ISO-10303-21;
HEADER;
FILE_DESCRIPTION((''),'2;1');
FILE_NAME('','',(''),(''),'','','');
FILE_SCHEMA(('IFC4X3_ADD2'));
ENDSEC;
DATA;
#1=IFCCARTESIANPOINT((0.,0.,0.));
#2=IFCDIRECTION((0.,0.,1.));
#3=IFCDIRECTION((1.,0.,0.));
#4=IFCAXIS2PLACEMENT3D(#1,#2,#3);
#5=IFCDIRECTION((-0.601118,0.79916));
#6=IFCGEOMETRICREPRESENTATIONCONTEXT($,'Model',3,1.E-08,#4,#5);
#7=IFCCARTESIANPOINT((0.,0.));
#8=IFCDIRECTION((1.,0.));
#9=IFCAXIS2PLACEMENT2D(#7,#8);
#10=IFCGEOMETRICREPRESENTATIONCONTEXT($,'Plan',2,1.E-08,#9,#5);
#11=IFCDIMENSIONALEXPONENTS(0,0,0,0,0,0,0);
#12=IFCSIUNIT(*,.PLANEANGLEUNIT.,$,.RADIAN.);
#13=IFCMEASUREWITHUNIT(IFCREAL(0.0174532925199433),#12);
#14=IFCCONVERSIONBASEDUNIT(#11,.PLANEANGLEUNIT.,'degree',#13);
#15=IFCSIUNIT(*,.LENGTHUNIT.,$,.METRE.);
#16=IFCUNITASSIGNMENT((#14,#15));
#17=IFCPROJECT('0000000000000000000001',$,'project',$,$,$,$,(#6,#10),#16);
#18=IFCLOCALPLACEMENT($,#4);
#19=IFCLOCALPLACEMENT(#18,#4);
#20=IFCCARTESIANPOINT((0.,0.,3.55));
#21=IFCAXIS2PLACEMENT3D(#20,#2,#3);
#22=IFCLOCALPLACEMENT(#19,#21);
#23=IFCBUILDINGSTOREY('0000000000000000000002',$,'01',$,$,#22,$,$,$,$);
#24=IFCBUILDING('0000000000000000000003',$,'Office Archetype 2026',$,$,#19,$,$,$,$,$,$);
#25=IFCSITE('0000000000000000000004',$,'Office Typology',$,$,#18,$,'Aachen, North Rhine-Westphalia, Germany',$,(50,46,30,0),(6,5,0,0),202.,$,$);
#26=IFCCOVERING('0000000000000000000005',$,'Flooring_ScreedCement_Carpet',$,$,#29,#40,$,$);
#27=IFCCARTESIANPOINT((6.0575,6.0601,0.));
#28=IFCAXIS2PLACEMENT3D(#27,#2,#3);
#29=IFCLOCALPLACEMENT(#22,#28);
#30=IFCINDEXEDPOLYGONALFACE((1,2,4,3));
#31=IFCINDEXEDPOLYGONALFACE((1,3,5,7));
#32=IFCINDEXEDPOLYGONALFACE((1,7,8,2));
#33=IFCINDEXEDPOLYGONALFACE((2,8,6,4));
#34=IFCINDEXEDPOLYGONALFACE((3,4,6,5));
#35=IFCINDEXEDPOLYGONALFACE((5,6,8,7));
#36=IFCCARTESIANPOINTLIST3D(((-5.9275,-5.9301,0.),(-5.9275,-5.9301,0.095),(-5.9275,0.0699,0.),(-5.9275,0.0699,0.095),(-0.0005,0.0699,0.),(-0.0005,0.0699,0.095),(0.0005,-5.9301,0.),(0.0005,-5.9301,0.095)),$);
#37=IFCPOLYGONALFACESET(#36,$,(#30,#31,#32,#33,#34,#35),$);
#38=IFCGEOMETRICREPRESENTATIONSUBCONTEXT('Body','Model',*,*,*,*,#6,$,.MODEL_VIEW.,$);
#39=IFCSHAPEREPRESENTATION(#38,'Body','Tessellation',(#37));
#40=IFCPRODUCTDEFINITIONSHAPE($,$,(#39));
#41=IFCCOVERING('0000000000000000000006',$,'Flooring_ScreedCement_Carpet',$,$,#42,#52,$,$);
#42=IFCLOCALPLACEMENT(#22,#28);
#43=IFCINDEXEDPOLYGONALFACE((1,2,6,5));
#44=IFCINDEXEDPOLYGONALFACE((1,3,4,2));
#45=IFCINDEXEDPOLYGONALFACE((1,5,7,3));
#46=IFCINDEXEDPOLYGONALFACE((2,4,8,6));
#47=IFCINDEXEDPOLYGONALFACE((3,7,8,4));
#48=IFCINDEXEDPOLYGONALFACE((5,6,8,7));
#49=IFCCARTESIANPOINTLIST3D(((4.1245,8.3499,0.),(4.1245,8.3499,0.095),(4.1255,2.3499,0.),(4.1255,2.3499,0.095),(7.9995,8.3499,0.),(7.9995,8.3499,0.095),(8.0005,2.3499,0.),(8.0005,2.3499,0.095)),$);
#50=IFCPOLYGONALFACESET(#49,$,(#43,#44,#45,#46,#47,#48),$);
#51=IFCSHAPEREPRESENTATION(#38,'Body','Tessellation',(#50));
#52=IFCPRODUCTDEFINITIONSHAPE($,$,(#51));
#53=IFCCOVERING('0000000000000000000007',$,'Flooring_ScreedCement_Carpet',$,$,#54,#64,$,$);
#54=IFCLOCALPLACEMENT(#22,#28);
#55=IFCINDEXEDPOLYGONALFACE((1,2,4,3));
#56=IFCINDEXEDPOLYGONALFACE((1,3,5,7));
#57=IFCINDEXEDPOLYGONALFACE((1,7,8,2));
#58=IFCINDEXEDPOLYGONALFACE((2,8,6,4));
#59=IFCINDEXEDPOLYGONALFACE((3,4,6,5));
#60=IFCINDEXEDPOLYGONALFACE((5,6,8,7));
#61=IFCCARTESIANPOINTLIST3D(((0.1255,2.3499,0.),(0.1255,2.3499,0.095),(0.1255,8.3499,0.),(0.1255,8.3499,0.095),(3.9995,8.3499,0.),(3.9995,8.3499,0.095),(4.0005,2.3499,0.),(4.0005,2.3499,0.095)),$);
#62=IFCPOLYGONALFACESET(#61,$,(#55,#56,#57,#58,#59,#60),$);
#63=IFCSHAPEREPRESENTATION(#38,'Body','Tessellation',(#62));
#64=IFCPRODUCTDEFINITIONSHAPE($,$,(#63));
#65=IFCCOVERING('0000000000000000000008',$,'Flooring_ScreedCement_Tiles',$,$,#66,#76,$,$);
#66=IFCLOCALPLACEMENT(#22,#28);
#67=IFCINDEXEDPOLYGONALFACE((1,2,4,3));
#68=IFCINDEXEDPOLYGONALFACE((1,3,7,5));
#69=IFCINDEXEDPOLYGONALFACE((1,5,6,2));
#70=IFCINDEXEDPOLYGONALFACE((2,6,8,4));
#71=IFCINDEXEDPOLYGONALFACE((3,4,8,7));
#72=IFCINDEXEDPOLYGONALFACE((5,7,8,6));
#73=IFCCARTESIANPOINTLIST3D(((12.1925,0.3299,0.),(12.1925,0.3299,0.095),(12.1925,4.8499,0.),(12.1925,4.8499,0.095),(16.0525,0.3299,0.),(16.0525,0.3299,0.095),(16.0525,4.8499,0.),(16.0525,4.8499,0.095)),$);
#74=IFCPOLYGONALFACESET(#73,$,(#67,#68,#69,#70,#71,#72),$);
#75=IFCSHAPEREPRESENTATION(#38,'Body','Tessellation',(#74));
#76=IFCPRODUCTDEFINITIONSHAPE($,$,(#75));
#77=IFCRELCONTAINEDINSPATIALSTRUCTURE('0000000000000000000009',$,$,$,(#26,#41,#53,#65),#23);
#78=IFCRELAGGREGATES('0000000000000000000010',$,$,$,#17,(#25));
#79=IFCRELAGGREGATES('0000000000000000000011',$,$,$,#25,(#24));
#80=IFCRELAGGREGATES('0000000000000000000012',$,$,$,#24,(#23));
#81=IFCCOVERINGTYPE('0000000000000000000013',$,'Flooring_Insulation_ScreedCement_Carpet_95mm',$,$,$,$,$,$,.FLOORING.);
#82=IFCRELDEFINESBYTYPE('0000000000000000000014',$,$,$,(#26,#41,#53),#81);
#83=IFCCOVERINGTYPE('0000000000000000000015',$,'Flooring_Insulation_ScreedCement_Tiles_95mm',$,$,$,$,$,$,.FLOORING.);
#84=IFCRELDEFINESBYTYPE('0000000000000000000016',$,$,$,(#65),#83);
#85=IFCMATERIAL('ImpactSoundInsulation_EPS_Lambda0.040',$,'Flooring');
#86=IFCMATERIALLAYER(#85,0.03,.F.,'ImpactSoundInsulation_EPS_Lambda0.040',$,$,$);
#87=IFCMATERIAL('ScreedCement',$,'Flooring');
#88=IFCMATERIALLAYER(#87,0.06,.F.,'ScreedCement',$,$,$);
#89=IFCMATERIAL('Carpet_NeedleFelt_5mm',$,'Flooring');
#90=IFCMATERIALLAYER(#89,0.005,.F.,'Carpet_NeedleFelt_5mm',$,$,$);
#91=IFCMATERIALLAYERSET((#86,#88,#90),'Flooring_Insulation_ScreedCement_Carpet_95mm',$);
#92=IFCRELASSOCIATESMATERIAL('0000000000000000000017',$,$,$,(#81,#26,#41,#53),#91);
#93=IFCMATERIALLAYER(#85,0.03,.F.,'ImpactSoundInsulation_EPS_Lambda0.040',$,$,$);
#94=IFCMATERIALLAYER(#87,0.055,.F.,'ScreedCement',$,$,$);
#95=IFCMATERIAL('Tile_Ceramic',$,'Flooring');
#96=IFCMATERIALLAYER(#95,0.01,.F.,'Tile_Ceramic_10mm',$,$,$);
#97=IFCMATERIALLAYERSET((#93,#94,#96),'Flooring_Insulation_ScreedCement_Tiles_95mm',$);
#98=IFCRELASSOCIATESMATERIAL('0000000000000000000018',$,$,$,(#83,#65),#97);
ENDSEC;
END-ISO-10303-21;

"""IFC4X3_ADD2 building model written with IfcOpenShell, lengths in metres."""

from ifc_helpers import new_model, entity, si_unit, converted_unit, direction, frame, origin_with_axes, origin_2d_with_axis, place, context, subcontext, project, spatial, line, indexed_curve, outline, extrude, material, layer, layer_set, layer_usage, type_object, element, save


model = new_model("IFC4X3_ADD2")

# Units and contexts
model_context = context("Model", 3, precision=1e-08, world=origin_with_axes(), true_north=direction((-0.601118, 0.79916)))
plan_context = context("Plan", 2, precision=1e-08, world=origin_2d_with_axis(), true_north=direction((-0.601118, 0.79916)))
body_context = subcontext(model_context, "Body", "Model", "MODEL_VIEW")
ifc_project = project(units=[converted_unit("PLANEANGLEUNIT", "degree", entity("IfcReal", 0.0174532925199433), si_unit("PLANEANGLEUNIT", "RADIAN"), dimensions=[0, 0, 0, 0, 0, 0, 0]), si_unit("LENGTHUNIT", "METRE")], contexts=[model_context, plan_context])

# Site, building, storey
site_placement = place(None, origin_with_axes())
site = spatial("IfcSite", under=ifc_project, at=site_placement, Name="Office Typology", LongName="Aachen, North Rhine-Westphalia, Germany", RefLatitude=(50, 46, 30, 0), RefLongitude=(6, 5, 0, 0), RefElevation=202.0)
building_placement = place(site_placement, origin_with_axes())
building = spatial("IfcBuilding", under=site, at=building_placement, Name="Office Archetype 2026")
storey_placement = place(building_placement, frame((0.0, 0.0, 3.55), z_axis=(0.0, 0.0, 1.0), x_axis=(1.0, 0.0, 0.0)))
storey = spatial("IfcBuildingStorey", under=building, at=storey_placement, Name="01")

# Coverings
ifc_material_1 = material(Name="ImpactSoundInsulation_EPS_Lambda0.040", Category="Flooring")
ifc_layer_1 = layer(ifc_material_1, 0.03, ventilated=False, Name="ImpactSoundInsulation_EPS_Lambda0.040")
ifc_material_2 = material(Name="ScreedCement", Category="Flooring")
ifc_layer_2 = layer(ifc_material_2, 0.06, ventilated=False, Name="ScreedCement")
ifc_material_3 = material(Name="Carpet_NeedleFelt_5mm", Category="Flooring")
ifc_layer_3 = layer(ifc_material_3, 0.005, ventilated=False, Name="Carpet_NeedleFelt_5mm")
ifc_layer_set_1 = layer_set([ifc_layer_1, ifc_layer_2, ifc_layer_3], Name="Flooring_Insulation_ScreedCement_Carpet_95mm")
ifc_layer_usage_1 = layer_usage(ifc_layer_set_1, "AXIS3", "POSITIVE", 0.0)
covering_type_1 = type_object("IfcCoveringType", Name="Flooring_Insulation_ScreedCement_Carpet_95mm", PredefinedType="FLOORING", material=ifc_layer_set_1)
covering_1_placement = place(storey_placement, frame((6.0575, 6.0601, 0.0), z_axis=(0.0, 0.0, 1.0), x_axis=(1.0, 0.0, 0.0)))
element("IfcCovering", 1, at=covering_1_placement, inside=storey, type_object=covering_type_1, material=ifc_layer_usage_1, Name="Flooring_ScreedCement_Carpet", context=body_context, shape_type="SweptSolid", body=[
    extrude(outline(indexed_curve([(-5.9275, -5.9301), (-5.9275, 0.0699), (-0.0005, 0.0699), (0.0005, -5.9301)], segments=[line(1, 2, 3, 4, 1)])), origin_with_axes(), (0.0, 0.0, 1.0), 0.095),
])
ifc_layer_usage_2 = layer_usage(ifc_layer_set_1, "AXIS3", "POSITIVE", 0.0)
covering_2_placement = place(storey_placement, frame((6.0575, 6.0601, 0.0), z_axis=(0.0, 0.0, 1.0), x_axis=(1.0, 0.0, 0.0)))
element("IfcCovering", 2, at=covering_2_placement, inside=storey, type_object=covering_type_1, material=ifc_layer_usage_2, Name="Flooring_ScreedCement_Carpet", context=body_context, shape_type="SweptSolid", body=[
    extrude(outline(indexed_curve([(4.1255, 2.3499), (4.1245, 8.3499), (7.9995, 8.3499), (8.0005, 2.3499)], segments=[line(1, 2, 3, 4, 1)])), origin_with_axes(), (0.0, 0.0, 1.0), 0.095),
])
ifc_layer_usage_3 = layer_usage(ifc_layer_set_1, "AXIS3", "POSITIVE", 0.0)
covering_3_placement = place(storey_placement, frame((6.0575, 6.0601, 0.0), z_axis=(0.0, 0.0, 1.0), x_axis=(1.0, 0.0, 0.0)))
element("IfcCovering", 3, at=covering_3_placement, inside=storey, type_object=covering_type_1, material=ifc_layer_usage_3, Name="Flooring_ScreedCement_Carpet", context=body_context, shape_type="SweptSolid", body=[
    extrude(outline(indexed_curve([(0.1255, 2.3499), (0.1255, 8.3499), (3.9995, 8.3499), (4.0005, 2.3499)], segments=[line(1, 2, 3, 4, 1)])), origin_with_axes(), (0.0, 0.0, 1.0), 0.095),
])
ifc_layer_4 = layer(ifc_material_1, 0.03, ventilated=False, Name="ImpactSoundInsulation_EPS_Lambda0.040")
ifc_layer_5 = layer(ifc_material_2, 0.055, ventilated=False, Name="ScreedCement")
ifc_material_4 = material(Name="Tile_Ceramic", Category="Flooring")
ifc_layer_6 = layer(ifc_material_4, 0.01, ventilated=False, Name="Tile_Ceramic_10mm")
ifc_layer_set_2 = layer_set([ifc_layer_4, ifc_layer_5, ifc_layer_6], Name="Flooring_Insulation_ScreedCement_Tiles_95mm")
ifc_layer_usage_4 = layer_usage(ifc_layer_set_2, "AXIS3", "POSITIVE", 0.0)
covering_type_2 = type_object("IfcCoveringType", Name="Flooring_Insulation_ScreedCement_Tiles_95mm", PredefinedType="FLOORING", material=ifc_layer_set_2)
covering_4_placement = place(storey_placement, frame((6.0575, 6.0601, 0.0), z_axis=(0.0, 0.0, 1.0), x_axis=(1.0, 0.0, 0.0)))
element("IfcCovering", 4, at=covering_4_placement, inside=storey, type_object=covering_type_2, material=ifc_layer_usage_4, Name="Flooring_ScreedCement_Tiles", context=body_context, shape_type="SweptSolid", body=[
    extrude(outline(indexed_curve([(12.1925, 0.3299), (12.1925, 4.8499), (16.0525, 4.8499), (16.0525, 0.3299)], segments=[line(1, 2, 3, 4, 1)])), origin_with_axes(), (0.0, 0.0, 1.0), 0.095),
])

save(model, "model.ifc")
